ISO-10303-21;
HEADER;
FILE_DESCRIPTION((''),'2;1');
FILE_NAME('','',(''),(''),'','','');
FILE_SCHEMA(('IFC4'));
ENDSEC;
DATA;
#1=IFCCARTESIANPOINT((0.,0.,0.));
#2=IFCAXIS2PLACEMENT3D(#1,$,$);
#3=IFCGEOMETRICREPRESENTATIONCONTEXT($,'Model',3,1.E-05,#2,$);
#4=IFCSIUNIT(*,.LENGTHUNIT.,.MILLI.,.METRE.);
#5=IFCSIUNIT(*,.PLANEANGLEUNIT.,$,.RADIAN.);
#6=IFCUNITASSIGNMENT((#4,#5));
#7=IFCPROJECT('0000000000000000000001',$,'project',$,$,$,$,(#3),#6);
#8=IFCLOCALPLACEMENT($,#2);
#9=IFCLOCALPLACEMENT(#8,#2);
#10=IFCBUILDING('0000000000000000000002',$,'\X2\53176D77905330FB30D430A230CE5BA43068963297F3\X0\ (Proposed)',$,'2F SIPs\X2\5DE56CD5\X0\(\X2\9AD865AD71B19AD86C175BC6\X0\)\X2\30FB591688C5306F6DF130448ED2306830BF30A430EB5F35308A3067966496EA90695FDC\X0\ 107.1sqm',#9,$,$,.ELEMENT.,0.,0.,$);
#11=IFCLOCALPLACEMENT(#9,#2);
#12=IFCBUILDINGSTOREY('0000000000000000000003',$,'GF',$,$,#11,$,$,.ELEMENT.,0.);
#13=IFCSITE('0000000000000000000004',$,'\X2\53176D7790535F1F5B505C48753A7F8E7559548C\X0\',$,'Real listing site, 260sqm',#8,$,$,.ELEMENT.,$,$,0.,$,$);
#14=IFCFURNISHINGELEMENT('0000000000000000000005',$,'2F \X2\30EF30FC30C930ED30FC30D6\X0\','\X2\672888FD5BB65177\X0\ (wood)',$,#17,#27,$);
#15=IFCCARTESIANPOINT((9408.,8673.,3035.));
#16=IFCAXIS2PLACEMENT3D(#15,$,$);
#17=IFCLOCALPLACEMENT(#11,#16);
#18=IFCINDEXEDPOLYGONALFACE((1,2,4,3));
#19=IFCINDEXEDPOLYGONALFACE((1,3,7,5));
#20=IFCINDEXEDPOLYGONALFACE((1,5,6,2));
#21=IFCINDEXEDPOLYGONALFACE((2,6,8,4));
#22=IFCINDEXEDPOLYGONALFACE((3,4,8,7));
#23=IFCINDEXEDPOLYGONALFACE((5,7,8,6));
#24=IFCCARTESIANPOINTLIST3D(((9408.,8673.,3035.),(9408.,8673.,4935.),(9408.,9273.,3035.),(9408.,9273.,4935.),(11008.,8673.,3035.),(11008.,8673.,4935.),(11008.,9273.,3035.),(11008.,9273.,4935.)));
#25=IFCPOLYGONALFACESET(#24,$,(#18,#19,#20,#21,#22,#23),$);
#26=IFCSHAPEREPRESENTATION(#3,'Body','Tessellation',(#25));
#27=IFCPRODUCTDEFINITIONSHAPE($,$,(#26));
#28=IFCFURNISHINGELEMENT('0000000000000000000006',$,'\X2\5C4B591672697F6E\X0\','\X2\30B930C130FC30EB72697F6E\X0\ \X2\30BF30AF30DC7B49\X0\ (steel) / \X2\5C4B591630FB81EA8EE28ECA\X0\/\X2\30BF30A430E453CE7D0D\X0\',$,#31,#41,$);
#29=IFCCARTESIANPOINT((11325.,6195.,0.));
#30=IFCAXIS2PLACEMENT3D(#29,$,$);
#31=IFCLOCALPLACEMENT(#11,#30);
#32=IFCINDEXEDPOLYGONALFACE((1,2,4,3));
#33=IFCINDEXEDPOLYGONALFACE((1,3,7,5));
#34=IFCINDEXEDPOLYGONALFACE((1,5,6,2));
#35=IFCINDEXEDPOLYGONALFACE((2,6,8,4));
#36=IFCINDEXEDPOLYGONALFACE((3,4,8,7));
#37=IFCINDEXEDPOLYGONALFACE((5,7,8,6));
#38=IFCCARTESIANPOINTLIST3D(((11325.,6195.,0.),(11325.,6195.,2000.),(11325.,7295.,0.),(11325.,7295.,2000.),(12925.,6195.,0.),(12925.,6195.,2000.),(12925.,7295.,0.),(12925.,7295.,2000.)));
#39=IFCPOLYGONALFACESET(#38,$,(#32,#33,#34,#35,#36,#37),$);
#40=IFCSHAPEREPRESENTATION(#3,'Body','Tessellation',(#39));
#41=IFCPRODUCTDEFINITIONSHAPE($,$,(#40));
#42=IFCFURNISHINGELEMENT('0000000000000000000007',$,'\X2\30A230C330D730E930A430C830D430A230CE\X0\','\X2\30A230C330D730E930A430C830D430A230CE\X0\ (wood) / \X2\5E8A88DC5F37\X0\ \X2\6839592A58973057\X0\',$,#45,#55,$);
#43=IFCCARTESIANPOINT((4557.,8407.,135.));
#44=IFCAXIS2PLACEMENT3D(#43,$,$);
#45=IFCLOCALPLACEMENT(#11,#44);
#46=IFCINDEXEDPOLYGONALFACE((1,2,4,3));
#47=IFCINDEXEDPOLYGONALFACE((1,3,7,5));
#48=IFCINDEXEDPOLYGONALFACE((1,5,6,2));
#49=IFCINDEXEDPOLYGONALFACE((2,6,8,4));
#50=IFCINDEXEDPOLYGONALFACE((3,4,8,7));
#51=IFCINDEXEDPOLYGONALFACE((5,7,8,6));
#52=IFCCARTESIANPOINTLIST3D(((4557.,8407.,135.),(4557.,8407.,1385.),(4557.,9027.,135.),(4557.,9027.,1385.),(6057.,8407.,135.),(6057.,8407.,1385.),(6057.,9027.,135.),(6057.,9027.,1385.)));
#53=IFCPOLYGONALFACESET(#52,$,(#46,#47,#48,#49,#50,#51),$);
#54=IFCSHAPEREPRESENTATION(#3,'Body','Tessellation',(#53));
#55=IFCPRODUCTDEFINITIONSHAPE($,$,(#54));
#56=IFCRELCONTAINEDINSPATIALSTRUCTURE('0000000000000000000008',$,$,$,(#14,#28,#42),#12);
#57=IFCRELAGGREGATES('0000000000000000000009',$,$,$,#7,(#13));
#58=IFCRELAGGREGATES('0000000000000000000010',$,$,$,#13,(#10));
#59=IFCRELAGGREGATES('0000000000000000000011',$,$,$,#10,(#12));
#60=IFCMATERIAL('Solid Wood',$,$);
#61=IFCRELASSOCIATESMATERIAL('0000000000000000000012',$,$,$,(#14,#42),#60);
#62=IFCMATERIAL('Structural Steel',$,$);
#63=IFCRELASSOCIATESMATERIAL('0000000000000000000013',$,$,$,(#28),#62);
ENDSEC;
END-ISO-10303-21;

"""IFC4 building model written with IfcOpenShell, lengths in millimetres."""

from ifc_helpers import new_model, si_unit, frame, frame_2d, origin, place, context, project, spatial, rectangle, extrude, material, element, save


model = new_model("IFC4")

# Units and contexts
model_context = context("Model", 3, precision=1e-05, world=origin())
ifc_project = project(units=[si_unit("LENGTHUNIT", "METRE", prefix="MILLI"), si_unit("PLANEANGLEUNIT", "RADIAN")], contexts=[model_context])

# Site, building, storey
site_placement = place(None, origin())
site = spatial("IfcSite", under=ifc_project, at=site_placement, Name="北海道弟子屈町美留和", ObjectType="Real listing site, 260sqm", CompositionType="ELEMENT", RefElevation=0.0)
building_placement = place(site_placement, origin())
building = spatial("IfcBuilding", under=site, at=building_placement, Name="北海道・ピアノ室と防音 (Proposed)", ObjectType="2F SIPs工法(高断熱高気密)・外装は深い軒とタイル張りで除雪適応 107.1sqm", CompositionType="ELEMENT", ElevationOfRefHeight=0.0, ElevationOfTerrain=0.0)
storey_placement = place(building_placement, origin())
storey = spatial("IfcBuildingStorey", under=building, at=storey_placement, Name="GF", CompositionType="ELEMENT", Elevation=0.0)

# Shared definitions
ifc_material_1 = material(Name="Solid Wood")

# Shared definitions
ifc_material_2 = material(Name="Structural Steel")

# Furnishing elements
furnishing_1_placement = place(storey_placement, frame((9408.0, 8673.0, 3035.0)))
element("IfcFurnishingElement", 1, at=furnishing_1_placement, inside=storey, material=ifc_material_1, Name="2F ワードローブ", Description="木製家具 (wood)", context=model_context, shape_type="SweptSolid", body=[
    extrude(rectangle(XDim=1600.0, YDim=600.0, at=frame_2d((800.0, 300.0))), frame((9408.0, 8673.0, 3035.0)), (0.0, 0.0, 1.0), 1900.0),
])
furnishing_2_placement = place(storey_placement, frame((11325.0, 6195.0, 0.0)))
element("IfcFurnishingElement", 2, at=furnishing_2_placement, inside=storey, material=ifc_material_2, Name="屋外物置", Description="スチール物置 タクボ等 (steel) / 屋外・自転車/タイヤ収納", context=model_context, shape_type="SweptSolid", body=[
    extrude(rectangle(XDim=1600.0, YDim=1100.0, at=frame_2d((800.0, 550.0))), frame((11325.0, 6195.0, 0.0)), (0.0, 0.0, 1.0), 2000.0),
])
furnishing_3_placement = place(storey_placement, frame((4557.0, 8407.0, 135.0)))
element("IfcFurnishingElement", 3, at=furnishing_3_placement, inside=storey, material=ifc_material_1, Name="アップライトピアノ", Description="アップライトピアノ (wood) / 床補強 根太増し", context=model_context, shape_type="SweptSolid", body=[
    extrude(rectangle(XDim=1500.0, YDim=620.0, at=frame_2d((750.0, 310.0))), frame((4557.0, 8407.0, 135.0)), (0.0, 0.0, 1.0), 1250.0),
])

save(model, "model.ifc")
